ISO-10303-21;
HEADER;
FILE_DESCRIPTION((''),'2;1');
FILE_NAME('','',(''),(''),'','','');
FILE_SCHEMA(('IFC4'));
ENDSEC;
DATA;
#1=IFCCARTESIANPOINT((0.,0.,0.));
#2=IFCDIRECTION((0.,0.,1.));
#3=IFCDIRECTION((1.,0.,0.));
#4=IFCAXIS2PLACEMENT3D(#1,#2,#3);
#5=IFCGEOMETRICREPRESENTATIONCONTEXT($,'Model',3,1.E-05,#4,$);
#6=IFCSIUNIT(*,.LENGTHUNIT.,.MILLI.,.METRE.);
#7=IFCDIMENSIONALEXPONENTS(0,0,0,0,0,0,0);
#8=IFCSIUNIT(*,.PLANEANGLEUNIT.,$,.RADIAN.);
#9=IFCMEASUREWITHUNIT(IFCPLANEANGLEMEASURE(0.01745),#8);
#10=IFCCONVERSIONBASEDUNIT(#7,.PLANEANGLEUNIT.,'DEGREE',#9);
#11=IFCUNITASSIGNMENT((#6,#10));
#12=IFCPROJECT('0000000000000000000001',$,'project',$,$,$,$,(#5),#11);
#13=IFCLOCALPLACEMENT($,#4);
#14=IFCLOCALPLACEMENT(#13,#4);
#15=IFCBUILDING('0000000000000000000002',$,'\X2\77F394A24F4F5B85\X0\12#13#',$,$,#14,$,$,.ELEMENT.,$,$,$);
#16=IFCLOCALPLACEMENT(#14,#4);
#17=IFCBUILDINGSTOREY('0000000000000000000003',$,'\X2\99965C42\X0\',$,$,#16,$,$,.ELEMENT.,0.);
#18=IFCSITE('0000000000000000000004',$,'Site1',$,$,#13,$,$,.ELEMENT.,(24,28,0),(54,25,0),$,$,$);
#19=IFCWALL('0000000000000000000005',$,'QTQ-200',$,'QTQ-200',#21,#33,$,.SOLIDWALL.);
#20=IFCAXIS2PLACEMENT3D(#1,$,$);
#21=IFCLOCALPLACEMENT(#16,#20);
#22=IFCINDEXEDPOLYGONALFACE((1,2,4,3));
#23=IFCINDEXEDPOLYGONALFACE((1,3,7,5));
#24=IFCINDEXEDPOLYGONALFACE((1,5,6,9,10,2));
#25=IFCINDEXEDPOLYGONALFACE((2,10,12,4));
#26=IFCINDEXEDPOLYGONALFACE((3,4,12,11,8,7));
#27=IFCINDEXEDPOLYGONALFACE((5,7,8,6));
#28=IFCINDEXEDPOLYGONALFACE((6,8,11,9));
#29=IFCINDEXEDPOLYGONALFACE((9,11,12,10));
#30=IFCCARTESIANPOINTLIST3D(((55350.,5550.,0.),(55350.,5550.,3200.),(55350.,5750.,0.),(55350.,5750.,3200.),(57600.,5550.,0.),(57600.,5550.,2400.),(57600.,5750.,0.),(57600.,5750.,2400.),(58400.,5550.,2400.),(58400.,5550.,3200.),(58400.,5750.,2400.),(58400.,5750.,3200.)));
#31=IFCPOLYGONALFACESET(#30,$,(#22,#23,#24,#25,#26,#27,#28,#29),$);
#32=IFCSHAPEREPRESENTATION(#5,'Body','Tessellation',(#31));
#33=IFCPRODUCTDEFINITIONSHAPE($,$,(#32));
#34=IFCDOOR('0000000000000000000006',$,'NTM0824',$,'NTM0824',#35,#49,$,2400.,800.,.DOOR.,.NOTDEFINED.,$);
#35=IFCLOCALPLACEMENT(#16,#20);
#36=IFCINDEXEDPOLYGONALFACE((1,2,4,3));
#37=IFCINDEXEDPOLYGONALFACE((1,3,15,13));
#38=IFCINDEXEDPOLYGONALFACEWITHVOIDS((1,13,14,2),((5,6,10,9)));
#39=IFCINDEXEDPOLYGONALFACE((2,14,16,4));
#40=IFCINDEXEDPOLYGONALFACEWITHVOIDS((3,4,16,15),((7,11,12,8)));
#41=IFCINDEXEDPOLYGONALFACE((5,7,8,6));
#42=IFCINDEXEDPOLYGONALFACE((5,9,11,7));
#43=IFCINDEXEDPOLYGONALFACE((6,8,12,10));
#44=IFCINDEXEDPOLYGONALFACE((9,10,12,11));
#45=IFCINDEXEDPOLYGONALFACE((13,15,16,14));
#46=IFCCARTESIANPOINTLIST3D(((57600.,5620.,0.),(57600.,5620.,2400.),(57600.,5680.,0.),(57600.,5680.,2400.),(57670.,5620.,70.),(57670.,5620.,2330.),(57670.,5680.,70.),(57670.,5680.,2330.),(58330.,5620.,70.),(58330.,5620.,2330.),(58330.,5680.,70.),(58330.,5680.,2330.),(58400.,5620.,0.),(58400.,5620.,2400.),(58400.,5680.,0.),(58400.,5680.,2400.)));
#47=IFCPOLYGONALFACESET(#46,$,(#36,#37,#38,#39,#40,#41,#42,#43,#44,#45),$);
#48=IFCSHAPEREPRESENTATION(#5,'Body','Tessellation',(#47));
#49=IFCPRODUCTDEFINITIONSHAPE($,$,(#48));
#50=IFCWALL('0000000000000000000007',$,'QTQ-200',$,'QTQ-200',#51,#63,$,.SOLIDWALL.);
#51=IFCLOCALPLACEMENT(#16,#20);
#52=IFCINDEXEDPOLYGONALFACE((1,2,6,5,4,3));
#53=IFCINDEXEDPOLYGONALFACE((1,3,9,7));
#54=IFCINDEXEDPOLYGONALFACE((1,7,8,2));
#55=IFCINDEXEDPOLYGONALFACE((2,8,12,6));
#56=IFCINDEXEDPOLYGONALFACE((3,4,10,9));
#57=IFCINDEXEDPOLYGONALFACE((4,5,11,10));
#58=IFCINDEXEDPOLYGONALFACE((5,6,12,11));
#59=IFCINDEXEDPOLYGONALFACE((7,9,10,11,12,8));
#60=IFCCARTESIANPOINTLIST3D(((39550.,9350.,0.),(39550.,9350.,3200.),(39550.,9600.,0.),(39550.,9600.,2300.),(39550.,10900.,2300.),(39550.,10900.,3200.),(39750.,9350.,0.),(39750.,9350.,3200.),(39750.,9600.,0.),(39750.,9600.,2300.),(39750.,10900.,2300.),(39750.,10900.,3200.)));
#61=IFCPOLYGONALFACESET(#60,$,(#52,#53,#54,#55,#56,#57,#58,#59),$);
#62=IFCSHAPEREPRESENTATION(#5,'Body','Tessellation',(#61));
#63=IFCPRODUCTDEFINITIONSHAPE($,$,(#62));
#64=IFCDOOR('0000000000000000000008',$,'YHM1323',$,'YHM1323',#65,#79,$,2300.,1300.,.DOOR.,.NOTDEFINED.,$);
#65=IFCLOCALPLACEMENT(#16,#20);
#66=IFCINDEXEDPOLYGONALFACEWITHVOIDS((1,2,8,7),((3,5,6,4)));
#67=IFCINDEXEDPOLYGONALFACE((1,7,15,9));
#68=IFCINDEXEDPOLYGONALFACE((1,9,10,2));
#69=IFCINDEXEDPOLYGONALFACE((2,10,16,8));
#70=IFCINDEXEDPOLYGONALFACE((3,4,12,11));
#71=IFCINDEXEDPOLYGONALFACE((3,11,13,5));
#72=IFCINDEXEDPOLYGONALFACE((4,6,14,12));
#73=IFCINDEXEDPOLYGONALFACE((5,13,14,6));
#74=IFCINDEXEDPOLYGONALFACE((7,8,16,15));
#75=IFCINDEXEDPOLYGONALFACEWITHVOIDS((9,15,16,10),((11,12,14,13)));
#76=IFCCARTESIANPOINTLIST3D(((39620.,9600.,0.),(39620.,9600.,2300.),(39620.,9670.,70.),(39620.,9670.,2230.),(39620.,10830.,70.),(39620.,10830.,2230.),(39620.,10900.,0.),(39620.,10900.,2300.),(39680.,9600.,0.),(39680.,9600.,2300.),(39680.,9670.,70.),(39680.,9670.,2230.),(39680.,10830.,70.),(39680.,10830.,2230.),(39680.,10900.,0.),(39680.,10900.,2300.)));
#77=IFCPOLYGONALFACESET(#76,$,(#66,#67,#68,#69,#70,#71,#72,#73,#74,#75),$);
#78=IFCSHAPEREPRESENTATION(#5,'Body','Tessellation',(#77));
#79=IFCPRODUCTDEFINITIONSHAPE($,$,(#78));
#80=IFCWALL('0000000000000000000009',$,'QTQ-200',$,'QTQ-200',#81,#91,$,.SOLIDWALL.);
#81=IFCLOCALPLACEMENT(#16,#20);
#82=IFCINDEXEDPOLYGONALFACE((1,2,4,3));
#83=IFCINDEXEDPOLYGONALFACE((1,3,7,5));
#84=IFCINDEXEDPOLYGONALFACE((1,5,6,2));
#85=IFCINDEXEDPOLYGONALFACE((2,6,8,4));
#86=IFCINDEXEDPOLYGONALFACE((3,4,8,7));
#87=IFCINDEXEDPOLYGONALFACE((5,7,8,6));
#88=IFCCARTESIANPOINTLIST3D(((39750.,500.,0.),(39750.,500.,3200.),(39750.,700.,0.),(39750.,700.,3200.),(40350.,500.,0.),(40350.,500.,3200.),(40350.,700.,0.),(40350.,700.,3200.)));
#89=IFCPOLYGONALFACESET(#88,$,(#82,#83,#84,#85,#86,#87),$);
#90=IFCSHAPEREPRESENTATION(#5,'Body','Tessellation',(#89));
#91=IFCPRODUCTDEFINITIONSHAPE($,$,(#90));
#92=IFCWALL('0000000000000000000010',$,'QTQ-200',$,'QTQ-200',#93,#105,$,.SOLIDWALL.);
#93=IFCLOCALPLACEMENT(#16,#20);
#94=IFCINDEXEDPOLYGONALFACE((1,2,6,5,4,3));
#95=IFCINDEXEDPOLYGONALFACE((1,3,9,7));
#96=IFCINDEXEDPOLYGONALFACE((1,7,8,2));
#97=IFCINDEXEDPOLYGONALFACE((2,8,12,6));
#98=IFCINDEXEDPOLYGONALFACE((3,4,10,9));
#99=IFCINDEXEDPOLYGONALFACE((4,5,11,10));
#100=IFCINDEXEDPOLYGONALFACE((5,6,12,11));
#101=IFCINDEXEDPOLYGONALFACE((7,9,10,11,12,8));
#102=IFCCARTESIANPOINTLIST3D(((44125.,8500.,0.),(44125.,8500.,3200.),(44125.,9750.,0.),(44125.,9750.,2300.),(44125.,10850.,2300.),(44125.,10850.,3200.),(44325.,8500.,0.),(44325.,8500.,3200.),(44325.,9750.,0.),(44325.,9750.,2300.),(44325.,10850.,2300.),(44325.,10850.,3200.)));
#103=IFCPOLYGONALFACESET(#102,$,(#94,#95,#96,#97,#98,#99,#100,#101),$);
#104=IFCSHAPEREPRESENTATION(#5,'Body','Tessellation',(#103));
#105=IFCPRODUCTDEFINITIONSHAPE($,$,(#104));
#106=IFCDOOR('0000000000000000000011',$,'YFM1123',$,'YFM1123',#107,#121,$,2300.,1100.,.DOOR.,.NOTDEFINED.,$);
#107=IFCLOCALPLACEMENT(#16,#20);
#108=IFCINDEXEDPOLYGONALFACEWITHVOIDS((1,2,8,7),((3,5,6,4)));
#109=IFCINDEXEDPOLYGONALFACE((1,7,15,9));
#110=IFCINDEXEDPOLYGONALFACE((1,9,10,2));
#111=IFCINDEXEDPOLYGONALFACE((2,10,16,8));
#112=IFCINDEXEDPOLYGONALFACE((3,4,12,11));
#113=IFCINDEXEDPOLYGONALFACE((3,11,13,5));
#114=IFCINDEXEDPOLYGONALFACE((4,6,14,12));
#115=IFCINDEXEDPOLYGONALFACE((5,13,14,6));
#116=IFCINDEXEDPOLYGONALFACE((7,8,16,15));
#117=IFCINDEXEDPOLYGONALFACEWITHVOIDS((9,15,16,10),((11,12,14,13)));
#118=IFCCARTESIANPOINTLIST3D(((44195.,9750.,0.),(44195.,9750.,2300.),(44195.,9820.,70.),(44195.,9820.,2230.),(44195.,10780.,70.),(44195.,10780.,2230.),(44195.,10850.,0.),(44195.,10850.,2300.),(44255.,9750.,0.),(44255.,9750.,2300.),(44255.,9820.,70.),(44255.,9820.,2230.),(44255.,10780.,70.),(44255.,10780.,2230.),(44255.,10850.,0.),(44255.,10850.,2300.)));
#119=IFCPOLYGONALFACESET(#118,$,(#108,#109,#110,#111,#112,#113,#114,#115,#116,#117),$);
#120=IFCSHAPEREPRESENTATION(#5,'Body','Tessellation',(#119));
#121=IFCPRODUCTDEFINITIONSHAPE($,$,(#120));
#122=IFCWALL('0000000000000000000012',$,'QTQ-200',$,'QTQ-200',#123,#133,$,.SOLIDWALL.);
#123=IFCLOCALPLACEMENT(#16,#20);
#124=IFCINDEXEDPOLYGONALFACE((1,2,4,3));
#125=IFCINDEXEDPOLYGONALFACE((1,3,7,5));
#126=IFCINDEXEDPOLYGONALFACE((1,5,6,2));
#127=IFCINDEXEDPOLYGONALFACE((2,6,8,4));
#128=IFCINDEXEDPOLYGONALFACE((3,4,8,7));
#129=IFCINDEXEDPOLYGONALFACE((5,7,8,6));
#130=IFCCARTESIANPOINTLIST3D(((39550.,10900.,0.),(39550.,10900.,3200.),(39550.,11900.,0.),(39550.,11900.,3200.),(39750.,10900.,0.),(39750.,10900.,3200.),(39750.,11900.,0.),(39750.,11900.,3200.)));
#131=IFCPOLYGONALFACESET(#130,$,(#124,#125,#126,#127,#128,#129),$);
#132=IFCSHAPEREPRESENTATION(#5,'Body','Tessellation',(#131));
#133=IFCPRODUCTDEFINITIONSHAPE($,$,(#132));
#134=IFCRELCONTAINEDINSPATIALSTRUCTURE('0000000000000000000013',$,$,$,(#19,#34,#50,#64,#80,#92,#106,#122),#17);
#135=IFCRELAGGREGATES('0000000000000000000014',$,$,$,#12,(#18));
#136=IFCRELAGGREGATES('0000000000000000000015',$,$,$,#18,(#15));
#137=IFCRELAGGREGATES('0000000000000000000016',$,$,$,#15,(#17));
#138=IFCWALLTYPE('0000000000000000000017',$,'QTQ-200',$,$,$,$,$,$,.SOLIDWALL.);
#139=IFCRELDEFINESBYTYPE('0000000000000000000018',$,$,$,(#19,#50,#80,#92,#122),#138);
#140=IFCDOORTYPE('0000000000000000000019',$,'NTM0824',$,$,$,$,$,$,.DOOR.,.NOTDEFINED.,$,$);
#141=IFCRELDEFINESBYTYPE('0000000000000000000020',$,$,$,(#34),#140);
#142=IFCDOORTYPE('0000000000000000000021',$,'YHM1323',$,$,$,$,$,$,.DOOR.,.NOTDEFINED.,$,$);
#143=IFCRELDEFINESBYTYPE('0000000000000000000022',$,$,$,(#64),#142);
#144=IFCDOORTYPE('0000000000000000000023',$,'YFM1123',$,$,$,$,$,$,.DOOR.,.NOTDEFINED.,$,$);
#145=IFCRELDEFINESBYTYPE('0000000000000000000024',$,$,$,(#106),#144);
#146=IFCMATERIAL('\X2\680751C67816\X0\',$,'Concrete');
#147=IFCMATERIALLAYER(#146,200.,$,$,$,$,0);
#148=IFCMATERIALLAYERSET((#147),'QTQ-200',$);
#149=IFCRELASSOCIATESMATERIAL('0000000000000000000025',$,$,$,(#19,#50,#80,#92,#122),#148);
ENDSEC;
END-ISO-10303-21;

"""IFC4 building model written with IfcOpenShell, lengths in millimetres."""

from ifc_helpers import new_model, entity, si_unit, converted_unit, frame, origin_with_axes, place, context, project, spatial, polyline, outline, extrude, material, layer, layer_set, type_object, element, fill, save


model = new_model("IFC4")

# Units and contexts
model_context = context("Model", 3, precision=1e-05, world=origin_with_axes())
ifc_project = project(units=[si_unit("LENGTHUNIT", "METRE", prefix="MILLI"), converted_unit("PLANEANGLEUNIT", "DEGREE", entity("IfcPlaneAngleMeasure", 0.01745), si_unit("PLANEANGLEUNIT", "RADIAN"), dimensions=[0, 0, 0, 0, 0, 0, 0])], contexts=[model_context])

# Site, building, storey
site_placement = place(None, origin_with_axes())
site = spatial("IfcSite", under=ifc_project, at=site_placement, Name="Site1", CompositionType="ELEMENT", RefLatitude=(24, 28, 0), RefLongitude=(54, 25, 0))
building_placement = place(site_placement, origin_with_axes())
building = spatial("IfcBuilding", under=site, at=building_placement, Name="石钢住宅12#13#", CompositionType="ELEMENT")
storey_placement = place(building_placement, origin_with_axes())
storey = spatial("IfcBuildingStorey", under=building, at=storey_placement, Name="首层", CompositionType="ELEMENT", Elevation=0.0)

# Shared definitions
ifc_material = material(Name="标准砖", Category="Concrete")
ifc_layer = layer(ifc_material, 200.0, Priority=0)
ifc_layer_set = layer_set([ifc_layer], Name="QTQ-200")
wall_type = type_object("IfcWallType", Name="QTQ-200", PredefinedType="SOLIDWALL")

# Walls, openings, doors
wall_1_placement = place(storey_placement, origin_with_axes())
wall_1 = element("IfcWall", 1, at=wall_1_placement, inside=storey, type_object=wall_type, material=ifc_layer_set, Name="QTQ-200", ObjectType="QTQ-200", PredefinedType="SOLIDWALL", context=model_context, shape_type="SweptSolid", body=[
    extrude(outline(polyline([(0.0, 0.0), (3200.0, 0.0), (3200.0, 3050.0), (0.0, 3050.0), (0.0, 0.0)])), frame((58400.0, 5550.0, 3200.0), z_axis=(0.0, 1.0, 0.0), x_axis=(0.0, 0.0, -1.0)), (0.0, 0.0, 1.0), 200.0),
])
opening_1_placement = place(storey_placement, origin_with_axes())
opening_1 = element("IfcOpeningElement", 2, at=opening_1_placement, cuts=wall_1, PredefinedType="OPENING", context=model_context, shape_type="SweptSolid", body=[
    extrude(outline(polyline([(0.0, 0.0), (800.0, 0.0), (800.0, 2400.0), (0.0, 2400.0), (0.0, 0.0)])), frame((58400.0, 4550.0, 0.0), z_axis=(0.0, 1.0, 0.0), x_axis=(-1.0, 0.0, 0.0)), (0.0, 0.0, 1.0), 2200.0),
])
door_type_1 = type_object("IfcDoorType", Name="NTM0824", OperationType="NOTDEFINED", PredefinedType="DOOR")
door_1_placement = place(storey_placement, origin_with_axes())
door_1 = element("IfcDoor", 3, at=door_1_placement, inside=storey, type_object=door_type_1, Name="NTM0824", ObjectType="NTM0824", OperationType="NOTDEFINED", OverallHeight=2400.0, OverallWidth=800.0, PredefinedType="DOOR", context=model_context, shape_type="SweptSolid", body=[
    extrude(outline(polyline([(-400.0, -1200.0), (400.0, -1200.0), (400.0, 1200.0), (-400.0, 1200.0), (-400.0, -1200.0)]), holes=[polyline([(-330.0, -1130.0), (-330.0, 1130.0), (330.0, 1130.0), (330.0, -1130.0), (-330.0, -1130.0)])]), frame((58000.0, 5620.0, 1200.0), z_axis=(0.0, 1.0, 0.0), x_axis=(-1.0, 0.0, 0.0)), (0.0, 0.0, 1.0), 60.0),
])
fill(opening_1, door_1)
wall_2_placement = place(storey_placement, origin_with_axes())
wall_2 = element("IfcWall", 4, at=wall_2_placement, inside=storey, type_object=wall_type, material=ifc_layer_set, Name="QTQ-200", ObjectType="QTQ-200", PredefinedType="SOLIDWALL", context=model_context, shape_type="SweptSolid", body=[
    extrude(outline(polyline([(0.0, 0.0), (3200.0, 0.0), (3200.0, 1550.0), (0.0, 1550.0), (0.0, 0.0)])), frame((39550.0, 9350.0, 3200.0), z_axis=(1.0, 0.0, 0.0), x_axis=(0.0, 0.0, -1.0)), (0.0, 0.0, 1.0), 200.0),
])
opening_2_placement = place(storey_placement, origin_with_axes())
opening_2 = element("IfcOpeningElement", 5, at=opening_2_placement, cuts=wall_2, PredefinedType="OPENING", context=model_context, shape_type="SweptSolid", body=[
    extrude(outline(polyline([(0.0, 0.0), (1300.0, 0.0), (1300.0, 2300.0), (0.0, 2300.0), (0.0, 0.0)])), frame((38550.0, 9600.0, 0.0), z_axis=(1.0, 0.0, 0.0), x_axis=(0.0, 1.0, 0.0)), (0.0, 0.0, 1.0), 2200.0),
])
door_type_2 = type_object("IfcDoorType", Name="YHM1323", OperationType="NOTDEFINED", PredefinedType="DOOR")
door_2_placement = place(storey_placement, origin_with_axes())
door_2 = element("IfcDoor", 6, at=door_2_placement, inside=storey, type_object=door_type_2, Name="YHM1323", ObjectType="YHM1323", OperationType="NOTDEFINED", OverallHeight=2300.0, OverallWidth=1300.0, PredefinedType="DOOR", context=model_context, shape_type="SweptSolid", body=[
    extrude(outline(polyline([(-650.0, -1150.0), (650.0, -1150.0), (650.0, 1150.0), (-650.0, 1150.0), (-650.0, -1150.0)]), holes=[polyline([(-580.0, -1080.0), (-580.0, 1080.0), (580.0, 1080.0), (580.0, -1080.0), (-580.0, -1080.0)])]), frame((39620.0, 10250.0, 1150.0), z_axis=(1.0, 0.0, 0.0), x_axis=(0.0, 1.0, 0.0)), (0.0, 0.0, 1.0), 60.0),
])
fill(opening_2, door_2)

# Wall
wall_3_placement = place(storey_placement, origin_with_axes())
element("IfcWall", 7, at=wall_3_placement, inside=storey, type_object=wall_type, material=ifc_layer_set, Name="QTQ-200", ObjectType="QTQ-200", PredefinedType="SOLIDWALL", context=model_context, shape_type="SweptSolid", body=[
    extrude(outline(polyline([(0.0, 0.0), (3200.0, 0.0), (3200.0, 600.0), (0.0, 600.0), (0.0, 0.0)])), frame((40350.0, 500.0, 3200.0), z_axis=(0.0, 1.0, 0.0), x_axis=(0.0, 0.0, -1.0)), (0.0, 0.0, 1.0), 200.0),
])

# Wall, opening, door
wall_4_placement = place(storey_placement, origin_with_axes())
wall_4 = element("IfcWall", 8, at=wall_4_placement, inside=storey, type_object=wall_type, material=ifc_layer_set, Name="QTQ-200", ObjectType="QTQ-200", PredefinedType="SOLIDWALL", context=model_context, shape_type="SweptSolid", body=[
    extrude(outline(polyline([(0.0, 0.0), (3200.0, 0.0), (3200.0, 2350.0), (0.0, 2350.0), (0.0, 0.0)])), frame((44325.0, 10850.0, 3200.0), z_axis=(-1.0, 0.0, 0.0), x_axis=(0.0, 0.0, -1.0)), (0.0, 0.0, 1.0), 200.0),
])
opening_3_placement = place(storey_placement, origin_with_axes())
opening_3 = element("IfcOpeningElement", 9, at=opening_3_placement, cuts=wall_4, PredefinedType="OPENING", context=model_context, shape_type="SweptSolid", body=[
    extrude(outline(polyline([(0.0, 0.0), (1100.0, 0.0), (1100.0, 2300.0), (0.0, 2300.0), (0.0, 0.0)])), frame((45325.0, 10850.0, 0.0), z_axis=(-1.0, 0.0, 0.0), x_axis=(0.0, -1.0, 0.0)), (0.0, 0.0, 1.0), 2200.0),
])
door_type_3 = type_object("IfcDoorType", Name="YFM1123", OperationType="NOTDEFINED", PredefinedType="DOOR")
door_3_placement = place(storey_placement, origin_with_axes())
door_3 = element("IfcDoor", 10, at=door_3_placement, inside=storey, type_object=door_type_3, Name="YFM1123", ObjectType="YFM1123", OperationType="NOTDEFINED", OverallHeight=2300.0, OverallWidth=1100.0, PredefinedType="DOOR", context=model_context, shape_type="SweptSolid", body=[
    extrude(outline(polyline([(-550.0, -1150.0), (550.0, -1150.0), (550.0, 1150.0), (-550.0, 1150.0), (-550.0, -1150.0)]), holes=[polyline([(-480.0, -1080.0), (-480.0, 1080.0), (480.0, 1080.0), (480.0, -1080.0), (-480.0, -1080.0)])]), frame((44255.0, 10300.0, 1150.0), z_axis=(-1.0, 0.0, 0.0), x_axis=(0.0, -1.0, 0.0)), (0.0, 0.0, 1.0), 60.0),
])
fill(opening_3, door_3)

# Wall
wall_5_placement = place(storey_placement, origin_with_axes())
element("IfcWall", 11, at=wall_5_placement, inside=storey, type_object=wall_type, material=ifc_layer_set, Name="QTQ-200", ObjectType="QTQ-200", PredefinedType="SOLIDWALL", context=model_context, shape_type="SweptSolid", body=[
    extrude(outline(polyline([(0.0, 0.0), (3200.0, 0.0), (3200.0, 1000.0), (0.0, 1000.0), (0.0, 0.0)])), frame((39550.0, 10900.0, 3200.0), z_axis=(1.0, 0.0, 0.0), x_axis=(0.0, 0.0, -1.0)), (0.0, 0.0, 1.0), 200.0),
])

save(model, "model.ifc")
